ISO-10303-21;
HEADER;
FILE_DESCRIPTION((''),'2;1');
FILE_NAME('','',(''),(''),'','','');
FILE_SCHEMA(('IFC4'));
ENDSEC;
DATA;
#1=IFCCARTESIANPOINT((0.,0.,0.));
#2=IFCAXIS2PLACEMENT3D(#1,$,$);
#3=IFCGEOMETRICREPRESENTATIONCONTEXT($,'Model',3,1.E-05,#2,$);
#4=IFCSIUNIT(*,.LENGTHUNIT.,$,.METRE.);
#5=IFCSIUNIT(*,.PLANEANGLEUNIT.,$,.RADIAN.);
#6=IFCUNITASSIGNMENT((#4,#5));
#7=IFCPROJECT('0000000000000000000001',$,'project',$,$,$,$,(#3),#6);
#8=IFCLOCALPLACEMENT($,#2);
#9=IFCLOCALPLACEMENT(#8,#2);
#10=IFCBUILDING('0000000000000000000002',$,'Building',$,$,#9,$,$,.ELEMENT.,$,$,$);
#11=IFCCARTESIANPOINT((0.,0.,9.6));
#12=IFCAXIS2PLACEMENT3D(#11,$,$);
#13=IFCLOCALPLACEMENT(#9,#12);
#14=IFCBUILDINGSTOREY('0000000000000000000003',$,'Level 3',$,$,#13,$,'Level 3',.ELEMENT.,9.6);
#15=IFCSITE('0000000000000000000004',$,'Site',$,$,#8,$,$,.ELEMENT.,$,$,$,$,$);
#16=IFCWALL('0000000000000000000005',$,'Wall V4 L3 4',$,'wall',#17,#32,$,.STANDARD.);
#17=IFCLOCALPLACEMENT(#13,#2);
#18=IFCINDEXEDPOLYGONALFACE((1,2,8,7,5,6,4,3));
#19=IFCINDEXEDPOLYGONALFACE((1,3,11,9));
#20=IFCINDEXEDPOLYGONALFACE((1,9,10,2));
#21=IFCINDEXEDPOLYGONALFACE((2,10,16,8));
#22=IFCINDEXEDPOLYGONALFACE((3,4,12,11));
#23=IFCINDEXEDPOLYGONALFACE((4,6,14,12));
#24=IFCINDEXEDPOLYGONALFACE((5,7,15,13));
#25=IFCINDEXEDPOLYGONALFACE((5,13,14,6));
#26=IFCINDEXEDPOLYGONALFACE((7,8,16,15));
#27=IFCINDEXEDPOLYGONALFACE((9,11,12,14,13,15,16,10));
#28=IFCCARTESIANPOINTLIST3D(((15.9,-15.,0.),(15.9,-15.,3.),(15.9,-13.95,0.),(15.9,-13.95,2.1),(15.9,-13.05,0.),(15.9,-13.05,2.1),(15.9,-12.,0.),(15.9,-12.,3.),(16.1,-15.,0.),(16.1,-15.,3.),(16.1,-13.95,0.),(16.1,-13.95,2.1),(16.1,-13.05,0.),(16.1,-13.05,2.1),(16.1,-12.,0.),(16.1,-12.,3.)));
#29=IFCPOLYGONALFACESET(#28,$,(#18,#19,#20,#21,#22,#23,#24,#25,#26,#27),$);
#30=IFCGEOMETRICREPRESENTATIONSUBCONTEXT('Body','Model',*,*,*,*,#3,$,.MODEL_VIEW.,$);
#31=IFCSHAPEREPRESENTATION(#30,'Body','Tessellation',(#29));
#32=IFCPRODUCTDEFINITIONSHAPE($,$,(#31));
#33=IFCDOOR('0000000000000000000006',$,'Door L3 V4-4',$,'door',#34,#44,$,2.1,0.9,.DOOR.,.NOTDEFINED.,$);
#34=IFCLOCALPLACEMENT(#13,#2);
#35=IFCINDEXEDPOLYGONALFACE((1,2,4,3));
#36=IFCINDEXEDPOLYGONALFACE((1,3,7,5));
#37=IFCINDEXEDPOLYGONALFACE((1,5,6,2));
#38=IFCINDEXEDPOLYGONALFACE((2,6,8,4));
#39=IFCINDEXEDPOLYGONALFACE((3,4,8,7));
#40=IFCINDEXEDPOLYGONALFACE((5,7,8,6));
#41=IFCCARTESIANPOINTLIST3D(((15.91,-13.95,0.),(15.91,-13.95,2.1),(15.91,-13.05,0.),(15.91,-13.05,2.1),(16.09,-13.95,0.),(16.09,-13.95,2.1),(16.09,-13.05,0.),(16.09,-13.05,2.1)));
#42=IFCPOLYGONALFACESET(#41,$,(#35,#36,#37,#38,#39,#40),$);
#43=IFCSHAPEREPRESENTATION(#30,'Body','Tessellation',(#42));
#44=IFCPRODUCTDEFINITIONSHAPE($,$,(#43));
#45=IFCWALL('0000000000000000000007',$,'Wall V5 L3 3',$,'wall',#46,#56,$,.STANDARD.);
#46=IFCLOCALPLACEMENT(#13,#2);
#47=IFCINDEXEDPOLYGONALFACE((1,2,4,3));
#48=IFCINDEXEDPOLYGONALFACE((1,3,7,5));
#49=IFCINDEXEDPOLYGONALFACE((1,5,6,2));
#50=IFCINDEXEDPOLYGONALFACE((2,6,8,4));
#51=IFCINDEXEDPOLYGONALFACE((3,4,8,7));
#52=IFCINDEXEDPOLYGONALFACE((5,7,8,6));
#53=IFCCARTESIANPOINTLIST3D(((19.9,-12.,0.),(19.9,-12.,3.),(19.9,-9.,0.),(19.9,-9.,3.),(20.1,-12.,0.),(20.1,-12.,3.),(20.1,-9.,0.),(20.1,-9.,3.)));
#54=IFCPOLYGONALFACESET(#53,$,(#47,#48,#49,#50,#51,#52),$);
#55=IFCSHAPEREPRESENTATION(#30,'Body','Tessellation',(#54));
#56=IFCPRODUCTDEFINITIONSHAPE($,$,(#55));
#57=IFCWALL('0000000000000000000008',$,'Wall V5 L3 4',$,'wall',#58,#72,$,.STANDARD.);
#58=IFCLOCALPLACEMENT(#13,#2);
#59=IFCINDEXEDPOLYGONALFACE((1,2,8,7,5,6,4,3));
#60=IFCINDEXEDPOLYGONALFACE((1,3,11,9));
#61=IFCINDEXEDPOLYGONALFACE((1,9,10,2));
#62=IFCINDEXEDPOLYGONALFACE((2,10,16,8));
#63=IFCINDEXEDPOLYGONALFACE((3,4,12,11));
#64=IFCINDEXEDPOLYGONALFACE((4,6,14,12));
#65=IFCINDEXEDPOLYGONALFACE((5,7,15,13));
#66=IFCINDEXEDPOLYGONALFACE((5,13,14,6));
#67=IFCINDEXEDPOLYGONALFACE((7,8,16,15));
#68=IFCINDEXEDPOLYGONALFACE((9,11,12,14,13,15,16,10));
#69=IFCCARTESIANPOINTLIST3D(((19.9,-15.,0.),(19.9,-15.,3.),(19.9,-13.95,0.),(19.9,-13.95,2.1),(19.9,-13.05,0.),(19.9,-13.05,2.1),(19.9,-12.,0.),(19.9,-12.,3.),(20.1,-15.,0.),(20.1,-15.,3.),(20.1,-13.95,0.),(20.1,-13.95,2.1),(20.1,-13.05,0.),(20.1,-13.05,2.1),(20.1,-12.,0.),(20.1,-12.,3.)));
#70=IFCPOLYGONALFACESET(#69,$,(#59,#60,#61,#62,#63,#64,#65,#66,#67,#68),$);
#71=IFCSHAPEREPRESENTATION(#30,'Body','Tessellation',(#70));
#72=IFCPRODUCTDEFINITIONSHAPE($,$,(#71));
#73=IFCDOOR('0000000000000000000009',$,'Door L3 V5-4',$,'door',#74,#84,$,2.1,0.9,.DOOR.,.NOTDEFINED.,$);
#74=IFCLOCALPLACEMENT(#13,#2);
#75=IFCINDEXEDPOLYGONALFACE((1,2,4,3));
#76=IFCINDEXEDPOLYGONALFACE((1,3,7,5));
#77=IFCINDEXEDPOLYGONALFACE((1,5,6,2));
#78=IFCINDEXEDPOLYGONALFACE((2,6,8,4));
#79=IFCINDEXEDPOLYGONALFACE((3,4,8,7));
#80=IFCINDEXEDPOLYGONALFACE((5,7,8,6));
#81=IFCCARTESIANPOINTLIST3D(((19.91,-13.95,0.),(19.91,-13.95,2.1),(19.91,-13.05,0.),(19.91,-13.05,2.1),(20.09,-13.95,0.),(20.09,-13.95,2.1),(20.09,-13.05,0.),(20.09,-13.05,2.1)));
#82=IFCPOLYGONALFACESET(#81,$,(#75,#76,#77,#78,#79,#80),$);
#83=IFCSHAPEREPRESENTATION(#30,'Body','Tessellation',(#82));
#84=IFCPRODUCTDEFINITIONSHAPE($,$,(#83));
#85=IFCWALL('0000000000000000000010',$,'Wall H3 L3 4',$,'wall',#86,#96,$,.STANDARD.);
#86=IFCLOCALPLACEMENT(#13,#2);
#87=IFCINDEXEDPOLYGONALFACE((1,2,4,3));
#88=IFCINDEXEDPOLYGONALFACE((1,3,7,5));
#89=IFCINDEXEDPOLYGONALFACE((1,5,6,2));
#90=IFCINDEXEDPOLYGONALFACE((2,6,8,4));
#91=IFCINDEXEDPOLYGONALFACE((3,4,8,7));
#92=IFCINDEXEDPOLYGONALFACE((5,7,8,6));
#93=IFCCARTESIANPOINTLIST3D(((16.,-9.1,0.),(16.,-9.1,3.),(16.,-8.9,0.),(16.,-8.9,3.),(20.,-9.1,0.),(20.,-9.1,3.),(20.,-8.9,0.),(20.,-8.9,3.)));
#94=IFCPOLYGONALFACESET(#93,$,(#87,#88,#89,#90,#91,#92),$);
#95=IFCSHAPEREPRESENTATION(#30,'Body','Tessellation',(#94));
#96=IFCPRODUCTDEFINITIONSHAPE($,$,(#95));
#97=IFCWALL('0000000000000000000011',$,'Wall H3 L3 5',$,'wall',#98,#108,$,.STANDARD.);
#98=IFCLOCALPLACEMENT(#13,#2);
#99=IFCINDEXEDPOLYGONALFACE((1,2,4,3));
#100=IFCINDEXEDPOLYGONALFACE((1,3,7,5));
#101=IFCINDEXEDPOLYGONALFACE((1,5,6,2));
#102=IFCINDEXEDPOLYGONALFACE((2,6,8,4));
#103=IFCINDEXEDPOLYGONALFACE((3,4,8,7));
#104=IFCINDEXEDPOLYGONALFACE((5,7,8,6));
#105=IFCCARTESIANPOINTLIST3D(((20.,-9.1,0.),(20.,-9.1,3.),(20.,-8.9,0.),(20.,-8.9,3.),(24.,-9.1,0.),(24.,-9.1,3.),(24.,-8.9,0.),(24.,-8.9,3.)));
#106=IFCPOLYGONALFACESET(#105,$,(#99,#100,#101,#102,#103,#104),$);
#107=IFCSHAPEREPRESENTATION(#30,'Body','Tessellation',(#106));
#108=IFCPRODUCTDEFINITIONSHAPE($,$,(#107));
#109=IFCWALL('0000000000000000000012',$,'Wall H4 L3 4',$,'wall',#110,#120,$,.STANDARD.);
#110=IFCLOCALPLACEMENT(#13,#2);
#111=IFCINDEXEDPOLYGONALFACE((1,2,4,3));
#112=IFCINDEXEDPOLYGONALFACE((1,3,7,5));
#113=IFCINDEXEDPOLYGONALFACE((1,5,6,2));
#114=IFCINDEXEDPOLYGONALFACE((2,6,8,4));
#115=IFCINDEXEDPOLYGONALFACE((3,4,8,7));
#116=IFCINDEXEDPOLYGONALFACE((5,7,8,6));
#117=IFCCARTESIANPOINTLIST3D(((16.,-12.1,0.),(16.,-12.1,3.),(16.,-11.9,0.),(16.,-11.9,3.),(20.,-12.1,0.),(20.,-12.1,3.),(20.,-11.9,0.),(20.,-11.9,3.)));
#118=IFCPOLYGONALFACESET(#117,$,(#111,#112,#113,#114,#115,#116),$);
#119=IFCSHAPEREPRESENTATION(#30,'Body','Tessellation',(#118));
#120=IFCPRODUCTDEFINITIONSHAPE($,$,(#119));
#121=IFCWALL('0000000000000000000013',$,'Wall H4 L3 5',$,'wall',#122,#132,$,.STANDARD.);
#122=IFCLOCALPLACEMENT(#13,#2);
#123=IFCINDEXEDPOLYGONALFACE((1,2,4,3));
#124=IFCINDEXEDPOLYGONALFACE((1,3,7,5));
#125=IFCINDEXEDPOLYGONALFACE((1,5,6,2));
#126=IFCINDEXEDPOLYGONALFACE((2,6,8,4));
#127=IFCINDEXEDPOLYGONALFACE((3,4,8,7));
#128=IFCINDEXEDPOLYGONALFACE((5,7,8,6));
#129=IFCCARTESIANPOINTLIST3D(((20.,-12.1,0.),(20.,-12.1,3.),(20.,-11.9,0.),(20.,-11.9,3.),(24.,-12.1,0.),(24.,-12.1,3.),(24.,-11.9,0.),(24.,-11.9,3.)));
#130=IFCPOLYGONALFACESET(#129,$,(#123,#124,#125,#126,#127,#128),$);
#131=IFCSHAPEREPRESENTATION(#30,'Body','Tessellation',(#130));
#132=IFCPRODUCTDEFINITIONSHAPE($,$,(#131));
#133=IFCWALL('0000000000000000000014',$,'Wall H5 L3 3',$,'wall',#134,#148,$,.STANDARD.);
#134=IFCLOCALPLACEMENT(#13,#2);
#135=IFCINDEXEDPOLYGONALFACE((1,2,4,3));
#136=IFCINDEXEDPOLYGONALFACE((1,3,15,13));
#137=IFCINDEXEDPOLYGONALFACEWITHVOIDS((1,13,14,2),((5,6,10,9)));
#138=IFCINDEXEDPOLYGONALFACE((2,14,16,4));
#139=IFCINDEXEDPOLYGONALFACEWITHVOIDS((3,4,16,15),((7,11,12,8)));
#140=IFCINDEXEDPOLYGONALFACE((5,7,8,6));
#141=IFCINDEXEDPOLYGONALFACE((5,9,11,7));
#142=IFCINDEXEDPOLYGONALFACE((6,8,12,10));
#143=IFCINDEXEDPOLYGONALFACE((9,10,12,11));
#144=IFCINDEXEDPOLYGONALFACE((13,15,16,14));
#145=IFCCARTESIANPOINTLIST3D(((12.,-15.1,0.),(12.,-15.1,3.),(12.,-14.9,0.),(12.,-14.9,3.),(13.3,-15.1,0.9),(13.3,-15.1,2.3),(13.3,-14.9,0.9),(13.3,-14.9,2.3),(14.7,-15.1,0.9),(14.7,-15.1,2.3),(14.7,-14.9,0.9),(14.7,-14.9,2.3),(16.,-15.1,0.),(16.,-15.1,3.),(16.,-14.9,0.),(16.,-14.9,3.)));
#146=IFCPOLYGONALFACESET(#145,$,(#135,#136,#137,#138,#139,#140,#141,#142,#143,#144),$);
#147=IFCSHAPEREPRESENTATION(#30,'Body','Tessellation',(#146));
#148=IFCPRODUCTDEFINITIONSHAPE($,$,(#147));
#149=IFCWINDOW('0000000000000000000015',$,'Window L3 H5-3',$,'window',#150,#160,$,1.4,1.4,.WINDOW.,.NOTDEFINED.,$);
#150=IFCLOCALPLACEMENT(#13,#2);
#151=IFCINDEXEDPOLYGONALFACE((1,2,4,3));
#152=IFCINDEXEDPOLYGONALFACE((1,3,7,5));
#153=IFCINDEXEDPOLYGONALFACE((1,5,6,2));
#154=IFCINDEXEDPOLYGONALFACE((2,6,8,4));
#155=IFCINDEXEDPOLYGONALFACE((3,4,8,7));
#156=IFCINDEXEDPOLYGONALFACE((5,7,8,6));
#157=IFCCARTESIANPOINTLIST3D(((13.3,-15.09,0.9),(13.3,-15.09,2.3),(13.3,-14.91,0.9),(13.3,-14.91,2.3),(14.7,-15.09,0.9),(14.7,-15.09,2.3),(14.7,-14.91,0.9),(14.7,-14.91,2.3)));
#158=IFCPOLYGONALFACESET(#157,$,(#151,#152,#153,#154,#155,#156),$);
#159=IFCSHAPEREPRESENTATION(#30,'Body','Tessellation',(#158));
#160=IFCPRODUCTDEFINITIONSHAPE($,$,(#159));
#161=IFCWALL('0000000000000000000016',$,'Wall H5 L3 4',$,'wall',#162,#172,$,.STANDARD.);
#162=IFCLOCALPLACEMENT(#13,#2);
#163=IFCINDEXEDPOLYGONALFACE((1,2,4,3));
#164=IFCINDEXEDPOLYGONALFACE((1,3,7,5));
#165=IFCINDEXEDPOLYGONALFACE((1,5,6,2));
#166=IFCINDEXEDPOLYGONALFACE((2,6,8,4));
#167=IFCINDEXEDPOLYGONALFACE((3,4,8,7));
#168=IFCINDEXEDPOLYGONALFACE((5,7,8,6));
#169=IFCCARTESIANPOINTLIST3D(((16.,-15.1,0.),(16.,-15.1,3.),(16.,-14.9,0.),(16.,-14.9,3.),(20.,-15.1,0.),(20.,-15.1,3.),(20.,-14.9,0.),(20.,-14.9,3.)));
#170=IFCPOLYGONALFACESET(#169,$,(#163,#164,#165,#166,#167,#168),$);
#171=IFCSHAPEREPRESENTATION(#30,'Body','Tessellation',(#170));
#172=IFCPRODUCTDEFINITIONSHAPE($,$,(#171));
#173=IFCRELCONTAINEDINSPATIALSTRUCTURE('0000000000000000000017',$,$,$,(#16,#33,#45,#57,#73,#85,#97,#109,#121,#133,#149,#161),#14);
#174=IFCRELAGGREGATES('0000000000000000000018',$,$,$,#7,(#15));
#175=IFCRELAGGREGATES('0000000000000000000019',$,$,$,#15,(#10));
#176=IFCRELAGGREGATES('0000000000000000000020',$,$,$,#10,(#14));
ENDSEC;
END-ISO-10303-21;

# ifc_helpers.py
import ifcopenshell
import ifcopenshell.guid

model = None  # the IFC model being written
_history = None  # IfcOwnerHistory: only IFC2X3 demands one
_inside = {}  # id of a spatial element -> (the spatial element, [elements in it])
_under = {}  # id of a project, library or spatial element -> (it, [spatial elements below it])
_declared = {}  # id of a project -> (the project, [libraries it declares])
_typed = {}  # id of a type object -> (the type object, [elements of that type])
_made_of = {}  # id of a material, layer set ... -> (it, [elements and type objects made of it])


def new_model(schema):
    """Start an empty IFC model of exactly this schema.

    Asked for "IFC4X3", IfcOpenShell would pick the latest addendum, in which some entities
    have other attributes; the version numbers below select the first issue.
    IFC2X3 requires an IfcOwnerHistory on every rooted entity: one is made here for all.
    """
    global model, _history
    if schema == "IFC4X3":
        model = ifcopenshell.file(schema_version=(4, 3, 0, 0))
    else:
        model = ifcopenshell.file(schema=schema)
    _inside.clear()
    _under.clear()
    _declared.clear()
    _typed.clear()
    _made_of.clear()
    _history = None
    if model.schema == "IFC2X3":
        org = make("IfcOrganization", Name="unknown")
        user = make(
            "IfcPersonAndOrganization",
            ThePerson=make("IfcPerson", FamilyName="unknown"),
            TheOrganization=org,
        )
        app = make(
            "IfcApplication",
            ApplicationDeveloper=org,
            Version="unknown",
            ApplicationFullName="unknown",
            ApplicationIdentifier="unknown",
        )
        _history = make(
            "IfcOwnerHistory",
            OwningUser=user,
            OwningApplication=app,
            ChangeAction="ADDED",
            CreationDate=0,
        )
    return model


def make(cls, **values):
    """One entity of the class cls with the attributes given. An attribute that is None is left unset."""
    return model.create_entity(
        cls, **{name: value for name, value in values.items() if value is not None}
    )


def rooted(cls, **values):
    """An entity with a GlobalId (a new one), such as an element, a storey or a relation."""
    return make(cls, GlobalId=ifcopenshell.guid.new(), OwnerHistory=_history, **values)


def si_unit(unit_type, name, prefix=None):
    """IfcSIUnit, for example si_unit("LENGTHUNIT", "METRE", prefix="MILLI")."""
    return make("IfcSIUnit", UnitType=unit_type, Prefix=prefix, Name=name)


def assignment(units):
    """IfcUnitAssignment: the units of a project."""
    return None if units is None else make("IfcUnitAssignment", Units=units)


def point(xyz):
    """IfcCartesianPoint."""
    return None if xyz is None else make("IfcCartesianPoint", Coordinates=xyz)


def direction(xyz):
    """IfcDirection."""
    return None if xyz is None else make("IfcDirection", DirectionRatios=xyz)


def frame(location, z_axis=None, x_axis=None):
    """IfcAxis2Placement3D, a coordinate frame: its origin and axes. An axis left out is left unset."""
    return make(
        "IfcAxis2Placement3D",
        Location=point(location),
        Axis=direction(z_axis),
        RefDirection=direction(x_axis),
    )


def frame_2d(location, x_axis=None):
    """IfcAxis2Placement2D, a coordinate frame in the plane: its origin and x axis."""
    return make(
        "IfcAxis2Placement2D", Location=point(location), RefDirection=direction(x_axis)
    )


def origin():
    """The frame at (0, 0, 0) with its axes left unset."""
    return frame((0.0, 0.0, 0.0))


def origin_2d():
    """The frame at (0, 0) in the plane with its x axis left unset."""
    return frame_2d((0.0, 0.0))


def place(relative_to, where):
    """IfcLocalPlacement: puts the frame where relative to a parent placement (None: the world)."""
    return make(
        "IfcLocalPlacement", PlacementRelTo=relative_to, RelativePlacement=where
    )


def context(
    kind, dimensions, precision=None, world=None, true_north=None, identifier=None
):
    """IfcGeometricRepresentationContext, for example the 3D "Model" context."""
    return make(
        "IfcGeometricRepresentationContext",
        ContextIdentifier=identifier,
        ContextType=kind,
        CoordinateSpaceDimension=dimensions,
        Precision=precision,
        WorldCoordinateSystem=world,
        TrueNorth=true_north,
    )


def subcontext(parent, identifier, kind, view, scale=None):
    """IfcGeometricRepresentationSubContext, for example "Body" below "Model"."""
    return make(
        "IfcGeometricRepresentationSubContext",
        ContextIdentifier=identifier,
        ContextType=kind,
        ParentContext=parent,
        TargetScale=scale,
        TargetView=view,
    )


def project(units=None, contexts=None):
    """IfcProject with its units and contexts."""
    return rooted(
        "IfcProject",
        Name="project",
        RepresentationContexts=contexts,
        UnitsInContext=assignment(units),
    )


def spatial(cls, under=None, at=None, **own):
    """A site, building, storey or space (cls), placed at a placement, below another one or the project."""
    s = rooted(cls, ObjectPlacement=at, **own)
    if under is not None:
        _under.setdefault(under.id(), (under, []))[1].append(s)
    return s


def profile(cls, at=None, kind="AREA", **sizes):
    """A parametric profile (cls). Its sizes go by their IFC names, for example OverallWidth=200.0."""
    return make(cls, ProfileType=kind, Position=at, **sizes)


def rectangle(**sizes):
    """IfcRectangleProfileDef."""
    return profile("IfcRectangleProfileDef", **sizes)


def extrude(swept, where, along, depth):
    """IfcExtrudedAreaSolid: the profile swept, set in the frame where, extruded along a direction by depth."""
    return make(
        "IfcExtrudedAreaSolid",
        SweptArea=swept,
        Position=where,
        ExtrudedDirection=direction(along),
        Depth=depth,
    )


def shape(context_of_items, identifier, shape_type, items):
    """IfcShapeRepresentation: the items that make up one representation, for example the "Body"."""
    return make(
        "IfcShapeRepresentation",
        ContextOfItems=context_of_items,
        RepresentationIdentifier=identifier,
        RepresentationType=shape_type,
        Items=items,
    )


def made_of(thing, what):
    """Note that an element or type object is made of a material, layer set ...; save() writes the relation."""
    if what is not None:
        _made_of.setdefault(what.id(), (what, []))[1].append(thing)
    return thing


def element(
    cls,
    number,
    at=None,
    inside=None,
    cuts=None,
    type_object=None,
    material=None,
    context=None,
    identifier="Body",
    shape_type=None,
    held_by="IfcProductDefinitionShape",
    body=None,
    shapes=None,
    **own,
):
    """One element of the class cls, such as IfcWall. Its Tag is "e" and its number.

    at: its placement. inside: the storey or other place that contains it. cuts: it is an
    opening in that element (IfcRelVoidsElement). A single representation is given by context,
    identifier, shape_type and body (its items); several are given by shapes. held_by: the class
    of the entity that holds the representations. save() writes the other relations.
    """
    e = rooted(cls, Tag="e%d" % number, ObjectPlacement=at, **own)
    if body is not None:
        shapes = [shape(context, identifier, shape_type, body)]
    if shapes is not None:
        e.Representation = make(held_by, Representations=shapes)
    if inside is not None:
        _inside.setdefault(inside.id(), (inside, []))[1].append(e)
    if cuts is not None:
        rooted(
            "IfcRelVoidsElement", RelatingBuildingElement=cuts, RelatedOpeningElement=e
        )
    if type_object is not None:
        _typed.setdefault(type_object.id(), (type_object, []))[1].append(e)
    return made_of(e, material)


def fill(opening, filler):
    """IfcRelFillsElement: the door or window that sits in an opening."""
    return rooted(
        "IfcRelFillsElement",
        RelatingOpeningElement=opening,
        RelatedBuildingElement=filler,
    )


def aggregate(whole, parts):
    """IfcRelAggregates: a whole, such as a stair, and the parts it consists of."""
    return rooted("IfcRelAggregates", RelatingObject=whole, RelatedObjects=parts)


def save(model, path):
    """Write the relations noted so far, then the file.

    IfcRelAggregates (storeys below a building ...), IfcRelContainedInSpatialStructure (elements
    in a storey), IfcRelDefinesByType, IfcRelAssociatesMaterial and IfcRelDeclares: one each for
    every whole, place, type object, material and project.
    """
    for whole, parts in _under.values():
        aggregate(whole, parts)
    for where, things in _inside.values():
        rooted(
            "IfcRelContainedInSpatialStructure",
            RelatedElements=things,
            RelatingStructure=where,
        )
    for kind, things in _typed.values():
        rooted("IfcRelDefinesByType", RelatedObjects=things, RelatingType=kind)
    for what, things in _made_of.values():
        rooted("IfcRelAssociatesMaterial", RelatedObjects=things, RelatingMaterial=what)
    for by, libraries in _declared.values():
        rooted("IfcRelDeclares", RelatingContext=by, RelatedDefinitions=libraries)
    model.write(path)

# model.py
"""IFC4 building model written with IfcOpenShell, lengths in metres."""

from ifc_helpers import new_model, si_unit, frame, frame_2d, origin, origin_2d, place, context, subcontext, project, spatial, rectangle, extrude, element, fill, save


model = new_model("IFC4")

# Units and contexts
model_context = context("Model", 3, precision=1e-05, world=origin())
body_context = subcontext(model_context, "Body", "Model", "MODEL_VIEW")
ifc_project = project(units=[si_unit("LENGTHUNIT", "METRE"), si_unit("PLANEANGLEUNIT", "RADIAN")], contexts=[model_context])

# Site, building, storey
site_placement = place(None, origin())
site = spatial("IfcSite", under=ifc_project, at=site_placement, Name="Site", CompositionType="ELEMENT")
building_placement = place(site_placement, origin())
building = spatial("IfcBuilding", under=site, at=building_placement, Name="Building", CompositionType="ELEMENT")
storey_placement = place(building_placement, frame((0.0, 0.0, 9.6)))
storey = spatial("IfcBuildingStorey", under=building, at=storey_placement, Name="Level 3", LongName="Level 3", CompositionType="ELEMENT", Elevation=9.6)

# Wall, opening, door
wall_1_placement = place(storey_placement, frame((16.0, -12.0, 0.0), z_axis=(0.0, 0.0, 1.0), x_axis=(0.0, -1.0, 0.0)))
wall_1 = element("IfcWall", 1, at=wall_1_placement, inside=storey, Name="Wall V4 L3 4", ObjectType="wall", PredefinedType="STANDARD", context=body_context, shape_type="SweptSolid", body=[
    extrude(rectangle(XDim=3.0, YDim=0.2, at=frame_2d((1.5, 0.0))), origin(), (0.0, 0.0, 1.0), 3.0),
])
opening_1_placement = place(storey_placement, frame((16.0, -13.5, 0.0), z_axis=(0.0, 0.0, 1.0), x_axis=(0.0, -1.0, 0.0)))
opening_1 = element("IfcOpeningElement", 2, at=opening_1_placement, cuts=wall_1, ObjectType="Opening", PredefinedType="OPENING", context=body_context, shape_type="SweptSolid", body=[
    extrude(rectangle(XDim=0.9, YDim=0.22, at=origin_2d()), origin(), (0.0, 0.0, 1.0), 2.1),
])
door_1_placement = place(storey_placement, frame((16.0, -13.5, 0.0), z_axis=(0.0, 0.0, 1.0), x_axis=(0.0, -1.0, 0.0)))
door_1 = element("IfcDoor", 3, at=door_1_placement, inside=storey, Name="Door L3 V4-4", ObjectType="door", OperationType="NOTDEFINED", OverallHeight=2.1, OverallWidth=0.9, PredefinedType="DOOR", context=body_context, shape_type="SweptSolid", body=[
    extrude(rectangle(XDim=0.9, YDim=0.18, at=origin_2d()), origin(), (0.0, 0.0, 1.0), 2.1),
])
fill(opening_1, door_1)

# Wall
wall_2_placement = place(storey_placement, frame((20.0, -9.0, 0.0), z_axis=(0.0, 0.0, 1.0), x_axis=(0.0, -1.0, 0.0)))
element("IfcWall", 4, at=wall_2_placement, inside=storey, Name="Wall V5 L3 3", ObjectType="wall", PredefinedType="STANDARD", context=body_context, shape_type="SweptSolid", body=[
    extrude(rectangle(XDim=3.0, YDim=0.2, at=frame_2d((1.5, 0.0))), origin(), (0.0, 0.0, 1.0), 3.0),
])

# Wall, opening, door
wall_3_placement = place(storey_placement, frame((20.0, -12.0, 0.0), z_axis=(0.0, 0.0, 1.0), x_axis=(0.0, -1.0, 0.0)))
wall_3 = element("IfcWall", 5, at=wall_3_placement, inside=storey, Name="Wall V5 L3 4", ObjectType="wall", PredefinedType="STANDARD", context=body_context, shape_type="SweptSolid", body=[
    extrude(rectangle(XDim=3.0, YDim=0.2, at=frame_2d((1.5, 0.0))), origin(), (0.0, 0.0, 1.0), 3.0),
])
opening_2_placement = place(storey_placement, frame((20.0, -13.5, 0.0), z_axis=(0.0, 0.0, 1.0), x_axis=(0.0, -1.0, 0.0)))
opening_2 = element("IfcOpeningElement", 6, at=opening_2_placement, cuts=wall_3, ObjectType="Opening", PredefinedType="OPENING", context=body_context, shape_type="SweptSolid", body=[
    extrude(rectangle(XDim=0.9, YDim=0.22, at=origin_2d()), origin(), (0.0, 0.0, 1.0), 2.1),
])
door_2_placement = place(storey_placement, frame((20.0, -13.5, 0.0), z_axis=(0.0, 0.0, 1.0), x_axis=(0.0, -1.0, 0.0)))
door_2 = element("IfcDoor", 7, at=door_2_placement, inside=storey, Name="Door L3 V5-4", ObjectType="door", OperationType="NOTDEFINED", OverallHeight=2.1, OverallWidth=0.9, PredefinedType="DOOR", context=body_context, shape_type="SweptSolid", body=[
    extrude(rectangle(XDim=0.9, YDim=0.18, at=origin_2d()), origin(), (0.0, 0.0, 1.0), 2.1),
])
fill(opening_2, door_2)

# Walls
for number, where, z_axis, x_axis, name in (
    (8, (16.0, -9.0, 0.0), (0.0, 0.0, 1.0), (1.0, 0.0, 0.0), "Wall H3 L3 4"),
    (9, (20.0, -9.0, 0.0), (0.0, 0.0, 1.0), (1.0, 0.0, 0.0), "Wall H3 L3 5"),
    (10, (16.0, -12.0, 0.0), (0.0, 0.0, 1.0), (1.0, 0.0, 0.0), "Wall H4 L3 4"),
    (11, (20.0, -12.0, 0.0), (0.0, 0.0, 1.0), (1.0, 0.0, 0.0), "Wall H4 L3 5"),
):
    element("IfcWall", number, at=place(storey_placement, frame(where, z_axis=z_axis, x_axis=x_axis)), inside=storey, Name=name, ObjectType="wall", PredefinedType="STANDARD", context=body_context, shape_type="SweptSolid", body=[
        extrude(rectangle(XDim=4.0, YDim=0.2, at=frame_2d((2.0, 0.0))), origin(), (0.0, 0.0, 1.0), 3.0),
    ])

# Wall, opening, window
wall_4_placement = place(storey_placement, frame((12.0, -15.0, 0.0), z_axis=(0.0, 0.0, 1.0), x_axis=(1.0, 0.0, 0.0)))
wall_4 = element("IfcWall", 12, at=wall_4_placement, inside=storey, Name="Wall H5 L3 3", ObjectType="wall", PredefinedType="STANDARD", context=body_context, shape_type="SweptSolid", body=[
    extrude(rectangle(XDim=4.0, YDim=0.2, at=frame_2d((2.0, 0.0))), origin(), (0.0, 0.0, 1.0), 3.0),
])
opening_3_placement = place(storey_placement, frame((14.0, -15.0, 0.9), z_axis=(0.0, 0.0, 1.0), x_axis=(1.0, 0.0, 0.0)))
opening_3 = element("IfcOpeningElement", 13, at=opening_3_placement, cuts=wall_4, ObjectType="Opening", PredefinedType="OPENING", context=body_context, shape_type="SweptSolid", body=[
    extrude(rectangle(XDim=1.4, YDim=0.22, at=origin_2d()), origin(), (0.0, 0.0, 1.0), 1.4),
])
window_1_placement = place(storey_placement, frame((14.0, -15.0, 0.9), z_axis=(0.0, 0.0, 1.0), x_axis=(1.0, 0.0, 0.0)))
window_1 = element("IfcWindow", 14, at=window_1_placement, inside=storey, Name="Window L3 H5-3", ObjectType="window", OverallHeight=1.4, OverallWidth=1.4, PartitioningType="NOTDEFINED", PredefinedType="WINDOW", context=body_context, shape_type="SweptSolid", body=[
    extrude(rectangle(XDim=1.4, YDim=0.18, at=origin_2d()), origin(), (0.0, 0.0, 1.0), 1.4),
])
fill(opening_3, window_1)

# Wall
wall_5_placement = place(storey_placement, frame((16.0, -15.0, 0.0), z_axis=(0.0, 0.0, 1.0), x_axis=(1.0, 0.0, 0.0)))
element("IfcWall", 15, at=wall_5_placement, inside=storey, Name="Wall H5 L3 4", ObjectType="wall", PredefinedType="STANDARD", context=body_context, shape_type="SweptSolid", body=[
    extrude(rectangle(XDim=4.0, YDim=0.2, at=frame_2d((2.0, 0.0))), origin(), (0.0, 0.0, 1.0), 3.0),
])

save(model, "model.ifc")
